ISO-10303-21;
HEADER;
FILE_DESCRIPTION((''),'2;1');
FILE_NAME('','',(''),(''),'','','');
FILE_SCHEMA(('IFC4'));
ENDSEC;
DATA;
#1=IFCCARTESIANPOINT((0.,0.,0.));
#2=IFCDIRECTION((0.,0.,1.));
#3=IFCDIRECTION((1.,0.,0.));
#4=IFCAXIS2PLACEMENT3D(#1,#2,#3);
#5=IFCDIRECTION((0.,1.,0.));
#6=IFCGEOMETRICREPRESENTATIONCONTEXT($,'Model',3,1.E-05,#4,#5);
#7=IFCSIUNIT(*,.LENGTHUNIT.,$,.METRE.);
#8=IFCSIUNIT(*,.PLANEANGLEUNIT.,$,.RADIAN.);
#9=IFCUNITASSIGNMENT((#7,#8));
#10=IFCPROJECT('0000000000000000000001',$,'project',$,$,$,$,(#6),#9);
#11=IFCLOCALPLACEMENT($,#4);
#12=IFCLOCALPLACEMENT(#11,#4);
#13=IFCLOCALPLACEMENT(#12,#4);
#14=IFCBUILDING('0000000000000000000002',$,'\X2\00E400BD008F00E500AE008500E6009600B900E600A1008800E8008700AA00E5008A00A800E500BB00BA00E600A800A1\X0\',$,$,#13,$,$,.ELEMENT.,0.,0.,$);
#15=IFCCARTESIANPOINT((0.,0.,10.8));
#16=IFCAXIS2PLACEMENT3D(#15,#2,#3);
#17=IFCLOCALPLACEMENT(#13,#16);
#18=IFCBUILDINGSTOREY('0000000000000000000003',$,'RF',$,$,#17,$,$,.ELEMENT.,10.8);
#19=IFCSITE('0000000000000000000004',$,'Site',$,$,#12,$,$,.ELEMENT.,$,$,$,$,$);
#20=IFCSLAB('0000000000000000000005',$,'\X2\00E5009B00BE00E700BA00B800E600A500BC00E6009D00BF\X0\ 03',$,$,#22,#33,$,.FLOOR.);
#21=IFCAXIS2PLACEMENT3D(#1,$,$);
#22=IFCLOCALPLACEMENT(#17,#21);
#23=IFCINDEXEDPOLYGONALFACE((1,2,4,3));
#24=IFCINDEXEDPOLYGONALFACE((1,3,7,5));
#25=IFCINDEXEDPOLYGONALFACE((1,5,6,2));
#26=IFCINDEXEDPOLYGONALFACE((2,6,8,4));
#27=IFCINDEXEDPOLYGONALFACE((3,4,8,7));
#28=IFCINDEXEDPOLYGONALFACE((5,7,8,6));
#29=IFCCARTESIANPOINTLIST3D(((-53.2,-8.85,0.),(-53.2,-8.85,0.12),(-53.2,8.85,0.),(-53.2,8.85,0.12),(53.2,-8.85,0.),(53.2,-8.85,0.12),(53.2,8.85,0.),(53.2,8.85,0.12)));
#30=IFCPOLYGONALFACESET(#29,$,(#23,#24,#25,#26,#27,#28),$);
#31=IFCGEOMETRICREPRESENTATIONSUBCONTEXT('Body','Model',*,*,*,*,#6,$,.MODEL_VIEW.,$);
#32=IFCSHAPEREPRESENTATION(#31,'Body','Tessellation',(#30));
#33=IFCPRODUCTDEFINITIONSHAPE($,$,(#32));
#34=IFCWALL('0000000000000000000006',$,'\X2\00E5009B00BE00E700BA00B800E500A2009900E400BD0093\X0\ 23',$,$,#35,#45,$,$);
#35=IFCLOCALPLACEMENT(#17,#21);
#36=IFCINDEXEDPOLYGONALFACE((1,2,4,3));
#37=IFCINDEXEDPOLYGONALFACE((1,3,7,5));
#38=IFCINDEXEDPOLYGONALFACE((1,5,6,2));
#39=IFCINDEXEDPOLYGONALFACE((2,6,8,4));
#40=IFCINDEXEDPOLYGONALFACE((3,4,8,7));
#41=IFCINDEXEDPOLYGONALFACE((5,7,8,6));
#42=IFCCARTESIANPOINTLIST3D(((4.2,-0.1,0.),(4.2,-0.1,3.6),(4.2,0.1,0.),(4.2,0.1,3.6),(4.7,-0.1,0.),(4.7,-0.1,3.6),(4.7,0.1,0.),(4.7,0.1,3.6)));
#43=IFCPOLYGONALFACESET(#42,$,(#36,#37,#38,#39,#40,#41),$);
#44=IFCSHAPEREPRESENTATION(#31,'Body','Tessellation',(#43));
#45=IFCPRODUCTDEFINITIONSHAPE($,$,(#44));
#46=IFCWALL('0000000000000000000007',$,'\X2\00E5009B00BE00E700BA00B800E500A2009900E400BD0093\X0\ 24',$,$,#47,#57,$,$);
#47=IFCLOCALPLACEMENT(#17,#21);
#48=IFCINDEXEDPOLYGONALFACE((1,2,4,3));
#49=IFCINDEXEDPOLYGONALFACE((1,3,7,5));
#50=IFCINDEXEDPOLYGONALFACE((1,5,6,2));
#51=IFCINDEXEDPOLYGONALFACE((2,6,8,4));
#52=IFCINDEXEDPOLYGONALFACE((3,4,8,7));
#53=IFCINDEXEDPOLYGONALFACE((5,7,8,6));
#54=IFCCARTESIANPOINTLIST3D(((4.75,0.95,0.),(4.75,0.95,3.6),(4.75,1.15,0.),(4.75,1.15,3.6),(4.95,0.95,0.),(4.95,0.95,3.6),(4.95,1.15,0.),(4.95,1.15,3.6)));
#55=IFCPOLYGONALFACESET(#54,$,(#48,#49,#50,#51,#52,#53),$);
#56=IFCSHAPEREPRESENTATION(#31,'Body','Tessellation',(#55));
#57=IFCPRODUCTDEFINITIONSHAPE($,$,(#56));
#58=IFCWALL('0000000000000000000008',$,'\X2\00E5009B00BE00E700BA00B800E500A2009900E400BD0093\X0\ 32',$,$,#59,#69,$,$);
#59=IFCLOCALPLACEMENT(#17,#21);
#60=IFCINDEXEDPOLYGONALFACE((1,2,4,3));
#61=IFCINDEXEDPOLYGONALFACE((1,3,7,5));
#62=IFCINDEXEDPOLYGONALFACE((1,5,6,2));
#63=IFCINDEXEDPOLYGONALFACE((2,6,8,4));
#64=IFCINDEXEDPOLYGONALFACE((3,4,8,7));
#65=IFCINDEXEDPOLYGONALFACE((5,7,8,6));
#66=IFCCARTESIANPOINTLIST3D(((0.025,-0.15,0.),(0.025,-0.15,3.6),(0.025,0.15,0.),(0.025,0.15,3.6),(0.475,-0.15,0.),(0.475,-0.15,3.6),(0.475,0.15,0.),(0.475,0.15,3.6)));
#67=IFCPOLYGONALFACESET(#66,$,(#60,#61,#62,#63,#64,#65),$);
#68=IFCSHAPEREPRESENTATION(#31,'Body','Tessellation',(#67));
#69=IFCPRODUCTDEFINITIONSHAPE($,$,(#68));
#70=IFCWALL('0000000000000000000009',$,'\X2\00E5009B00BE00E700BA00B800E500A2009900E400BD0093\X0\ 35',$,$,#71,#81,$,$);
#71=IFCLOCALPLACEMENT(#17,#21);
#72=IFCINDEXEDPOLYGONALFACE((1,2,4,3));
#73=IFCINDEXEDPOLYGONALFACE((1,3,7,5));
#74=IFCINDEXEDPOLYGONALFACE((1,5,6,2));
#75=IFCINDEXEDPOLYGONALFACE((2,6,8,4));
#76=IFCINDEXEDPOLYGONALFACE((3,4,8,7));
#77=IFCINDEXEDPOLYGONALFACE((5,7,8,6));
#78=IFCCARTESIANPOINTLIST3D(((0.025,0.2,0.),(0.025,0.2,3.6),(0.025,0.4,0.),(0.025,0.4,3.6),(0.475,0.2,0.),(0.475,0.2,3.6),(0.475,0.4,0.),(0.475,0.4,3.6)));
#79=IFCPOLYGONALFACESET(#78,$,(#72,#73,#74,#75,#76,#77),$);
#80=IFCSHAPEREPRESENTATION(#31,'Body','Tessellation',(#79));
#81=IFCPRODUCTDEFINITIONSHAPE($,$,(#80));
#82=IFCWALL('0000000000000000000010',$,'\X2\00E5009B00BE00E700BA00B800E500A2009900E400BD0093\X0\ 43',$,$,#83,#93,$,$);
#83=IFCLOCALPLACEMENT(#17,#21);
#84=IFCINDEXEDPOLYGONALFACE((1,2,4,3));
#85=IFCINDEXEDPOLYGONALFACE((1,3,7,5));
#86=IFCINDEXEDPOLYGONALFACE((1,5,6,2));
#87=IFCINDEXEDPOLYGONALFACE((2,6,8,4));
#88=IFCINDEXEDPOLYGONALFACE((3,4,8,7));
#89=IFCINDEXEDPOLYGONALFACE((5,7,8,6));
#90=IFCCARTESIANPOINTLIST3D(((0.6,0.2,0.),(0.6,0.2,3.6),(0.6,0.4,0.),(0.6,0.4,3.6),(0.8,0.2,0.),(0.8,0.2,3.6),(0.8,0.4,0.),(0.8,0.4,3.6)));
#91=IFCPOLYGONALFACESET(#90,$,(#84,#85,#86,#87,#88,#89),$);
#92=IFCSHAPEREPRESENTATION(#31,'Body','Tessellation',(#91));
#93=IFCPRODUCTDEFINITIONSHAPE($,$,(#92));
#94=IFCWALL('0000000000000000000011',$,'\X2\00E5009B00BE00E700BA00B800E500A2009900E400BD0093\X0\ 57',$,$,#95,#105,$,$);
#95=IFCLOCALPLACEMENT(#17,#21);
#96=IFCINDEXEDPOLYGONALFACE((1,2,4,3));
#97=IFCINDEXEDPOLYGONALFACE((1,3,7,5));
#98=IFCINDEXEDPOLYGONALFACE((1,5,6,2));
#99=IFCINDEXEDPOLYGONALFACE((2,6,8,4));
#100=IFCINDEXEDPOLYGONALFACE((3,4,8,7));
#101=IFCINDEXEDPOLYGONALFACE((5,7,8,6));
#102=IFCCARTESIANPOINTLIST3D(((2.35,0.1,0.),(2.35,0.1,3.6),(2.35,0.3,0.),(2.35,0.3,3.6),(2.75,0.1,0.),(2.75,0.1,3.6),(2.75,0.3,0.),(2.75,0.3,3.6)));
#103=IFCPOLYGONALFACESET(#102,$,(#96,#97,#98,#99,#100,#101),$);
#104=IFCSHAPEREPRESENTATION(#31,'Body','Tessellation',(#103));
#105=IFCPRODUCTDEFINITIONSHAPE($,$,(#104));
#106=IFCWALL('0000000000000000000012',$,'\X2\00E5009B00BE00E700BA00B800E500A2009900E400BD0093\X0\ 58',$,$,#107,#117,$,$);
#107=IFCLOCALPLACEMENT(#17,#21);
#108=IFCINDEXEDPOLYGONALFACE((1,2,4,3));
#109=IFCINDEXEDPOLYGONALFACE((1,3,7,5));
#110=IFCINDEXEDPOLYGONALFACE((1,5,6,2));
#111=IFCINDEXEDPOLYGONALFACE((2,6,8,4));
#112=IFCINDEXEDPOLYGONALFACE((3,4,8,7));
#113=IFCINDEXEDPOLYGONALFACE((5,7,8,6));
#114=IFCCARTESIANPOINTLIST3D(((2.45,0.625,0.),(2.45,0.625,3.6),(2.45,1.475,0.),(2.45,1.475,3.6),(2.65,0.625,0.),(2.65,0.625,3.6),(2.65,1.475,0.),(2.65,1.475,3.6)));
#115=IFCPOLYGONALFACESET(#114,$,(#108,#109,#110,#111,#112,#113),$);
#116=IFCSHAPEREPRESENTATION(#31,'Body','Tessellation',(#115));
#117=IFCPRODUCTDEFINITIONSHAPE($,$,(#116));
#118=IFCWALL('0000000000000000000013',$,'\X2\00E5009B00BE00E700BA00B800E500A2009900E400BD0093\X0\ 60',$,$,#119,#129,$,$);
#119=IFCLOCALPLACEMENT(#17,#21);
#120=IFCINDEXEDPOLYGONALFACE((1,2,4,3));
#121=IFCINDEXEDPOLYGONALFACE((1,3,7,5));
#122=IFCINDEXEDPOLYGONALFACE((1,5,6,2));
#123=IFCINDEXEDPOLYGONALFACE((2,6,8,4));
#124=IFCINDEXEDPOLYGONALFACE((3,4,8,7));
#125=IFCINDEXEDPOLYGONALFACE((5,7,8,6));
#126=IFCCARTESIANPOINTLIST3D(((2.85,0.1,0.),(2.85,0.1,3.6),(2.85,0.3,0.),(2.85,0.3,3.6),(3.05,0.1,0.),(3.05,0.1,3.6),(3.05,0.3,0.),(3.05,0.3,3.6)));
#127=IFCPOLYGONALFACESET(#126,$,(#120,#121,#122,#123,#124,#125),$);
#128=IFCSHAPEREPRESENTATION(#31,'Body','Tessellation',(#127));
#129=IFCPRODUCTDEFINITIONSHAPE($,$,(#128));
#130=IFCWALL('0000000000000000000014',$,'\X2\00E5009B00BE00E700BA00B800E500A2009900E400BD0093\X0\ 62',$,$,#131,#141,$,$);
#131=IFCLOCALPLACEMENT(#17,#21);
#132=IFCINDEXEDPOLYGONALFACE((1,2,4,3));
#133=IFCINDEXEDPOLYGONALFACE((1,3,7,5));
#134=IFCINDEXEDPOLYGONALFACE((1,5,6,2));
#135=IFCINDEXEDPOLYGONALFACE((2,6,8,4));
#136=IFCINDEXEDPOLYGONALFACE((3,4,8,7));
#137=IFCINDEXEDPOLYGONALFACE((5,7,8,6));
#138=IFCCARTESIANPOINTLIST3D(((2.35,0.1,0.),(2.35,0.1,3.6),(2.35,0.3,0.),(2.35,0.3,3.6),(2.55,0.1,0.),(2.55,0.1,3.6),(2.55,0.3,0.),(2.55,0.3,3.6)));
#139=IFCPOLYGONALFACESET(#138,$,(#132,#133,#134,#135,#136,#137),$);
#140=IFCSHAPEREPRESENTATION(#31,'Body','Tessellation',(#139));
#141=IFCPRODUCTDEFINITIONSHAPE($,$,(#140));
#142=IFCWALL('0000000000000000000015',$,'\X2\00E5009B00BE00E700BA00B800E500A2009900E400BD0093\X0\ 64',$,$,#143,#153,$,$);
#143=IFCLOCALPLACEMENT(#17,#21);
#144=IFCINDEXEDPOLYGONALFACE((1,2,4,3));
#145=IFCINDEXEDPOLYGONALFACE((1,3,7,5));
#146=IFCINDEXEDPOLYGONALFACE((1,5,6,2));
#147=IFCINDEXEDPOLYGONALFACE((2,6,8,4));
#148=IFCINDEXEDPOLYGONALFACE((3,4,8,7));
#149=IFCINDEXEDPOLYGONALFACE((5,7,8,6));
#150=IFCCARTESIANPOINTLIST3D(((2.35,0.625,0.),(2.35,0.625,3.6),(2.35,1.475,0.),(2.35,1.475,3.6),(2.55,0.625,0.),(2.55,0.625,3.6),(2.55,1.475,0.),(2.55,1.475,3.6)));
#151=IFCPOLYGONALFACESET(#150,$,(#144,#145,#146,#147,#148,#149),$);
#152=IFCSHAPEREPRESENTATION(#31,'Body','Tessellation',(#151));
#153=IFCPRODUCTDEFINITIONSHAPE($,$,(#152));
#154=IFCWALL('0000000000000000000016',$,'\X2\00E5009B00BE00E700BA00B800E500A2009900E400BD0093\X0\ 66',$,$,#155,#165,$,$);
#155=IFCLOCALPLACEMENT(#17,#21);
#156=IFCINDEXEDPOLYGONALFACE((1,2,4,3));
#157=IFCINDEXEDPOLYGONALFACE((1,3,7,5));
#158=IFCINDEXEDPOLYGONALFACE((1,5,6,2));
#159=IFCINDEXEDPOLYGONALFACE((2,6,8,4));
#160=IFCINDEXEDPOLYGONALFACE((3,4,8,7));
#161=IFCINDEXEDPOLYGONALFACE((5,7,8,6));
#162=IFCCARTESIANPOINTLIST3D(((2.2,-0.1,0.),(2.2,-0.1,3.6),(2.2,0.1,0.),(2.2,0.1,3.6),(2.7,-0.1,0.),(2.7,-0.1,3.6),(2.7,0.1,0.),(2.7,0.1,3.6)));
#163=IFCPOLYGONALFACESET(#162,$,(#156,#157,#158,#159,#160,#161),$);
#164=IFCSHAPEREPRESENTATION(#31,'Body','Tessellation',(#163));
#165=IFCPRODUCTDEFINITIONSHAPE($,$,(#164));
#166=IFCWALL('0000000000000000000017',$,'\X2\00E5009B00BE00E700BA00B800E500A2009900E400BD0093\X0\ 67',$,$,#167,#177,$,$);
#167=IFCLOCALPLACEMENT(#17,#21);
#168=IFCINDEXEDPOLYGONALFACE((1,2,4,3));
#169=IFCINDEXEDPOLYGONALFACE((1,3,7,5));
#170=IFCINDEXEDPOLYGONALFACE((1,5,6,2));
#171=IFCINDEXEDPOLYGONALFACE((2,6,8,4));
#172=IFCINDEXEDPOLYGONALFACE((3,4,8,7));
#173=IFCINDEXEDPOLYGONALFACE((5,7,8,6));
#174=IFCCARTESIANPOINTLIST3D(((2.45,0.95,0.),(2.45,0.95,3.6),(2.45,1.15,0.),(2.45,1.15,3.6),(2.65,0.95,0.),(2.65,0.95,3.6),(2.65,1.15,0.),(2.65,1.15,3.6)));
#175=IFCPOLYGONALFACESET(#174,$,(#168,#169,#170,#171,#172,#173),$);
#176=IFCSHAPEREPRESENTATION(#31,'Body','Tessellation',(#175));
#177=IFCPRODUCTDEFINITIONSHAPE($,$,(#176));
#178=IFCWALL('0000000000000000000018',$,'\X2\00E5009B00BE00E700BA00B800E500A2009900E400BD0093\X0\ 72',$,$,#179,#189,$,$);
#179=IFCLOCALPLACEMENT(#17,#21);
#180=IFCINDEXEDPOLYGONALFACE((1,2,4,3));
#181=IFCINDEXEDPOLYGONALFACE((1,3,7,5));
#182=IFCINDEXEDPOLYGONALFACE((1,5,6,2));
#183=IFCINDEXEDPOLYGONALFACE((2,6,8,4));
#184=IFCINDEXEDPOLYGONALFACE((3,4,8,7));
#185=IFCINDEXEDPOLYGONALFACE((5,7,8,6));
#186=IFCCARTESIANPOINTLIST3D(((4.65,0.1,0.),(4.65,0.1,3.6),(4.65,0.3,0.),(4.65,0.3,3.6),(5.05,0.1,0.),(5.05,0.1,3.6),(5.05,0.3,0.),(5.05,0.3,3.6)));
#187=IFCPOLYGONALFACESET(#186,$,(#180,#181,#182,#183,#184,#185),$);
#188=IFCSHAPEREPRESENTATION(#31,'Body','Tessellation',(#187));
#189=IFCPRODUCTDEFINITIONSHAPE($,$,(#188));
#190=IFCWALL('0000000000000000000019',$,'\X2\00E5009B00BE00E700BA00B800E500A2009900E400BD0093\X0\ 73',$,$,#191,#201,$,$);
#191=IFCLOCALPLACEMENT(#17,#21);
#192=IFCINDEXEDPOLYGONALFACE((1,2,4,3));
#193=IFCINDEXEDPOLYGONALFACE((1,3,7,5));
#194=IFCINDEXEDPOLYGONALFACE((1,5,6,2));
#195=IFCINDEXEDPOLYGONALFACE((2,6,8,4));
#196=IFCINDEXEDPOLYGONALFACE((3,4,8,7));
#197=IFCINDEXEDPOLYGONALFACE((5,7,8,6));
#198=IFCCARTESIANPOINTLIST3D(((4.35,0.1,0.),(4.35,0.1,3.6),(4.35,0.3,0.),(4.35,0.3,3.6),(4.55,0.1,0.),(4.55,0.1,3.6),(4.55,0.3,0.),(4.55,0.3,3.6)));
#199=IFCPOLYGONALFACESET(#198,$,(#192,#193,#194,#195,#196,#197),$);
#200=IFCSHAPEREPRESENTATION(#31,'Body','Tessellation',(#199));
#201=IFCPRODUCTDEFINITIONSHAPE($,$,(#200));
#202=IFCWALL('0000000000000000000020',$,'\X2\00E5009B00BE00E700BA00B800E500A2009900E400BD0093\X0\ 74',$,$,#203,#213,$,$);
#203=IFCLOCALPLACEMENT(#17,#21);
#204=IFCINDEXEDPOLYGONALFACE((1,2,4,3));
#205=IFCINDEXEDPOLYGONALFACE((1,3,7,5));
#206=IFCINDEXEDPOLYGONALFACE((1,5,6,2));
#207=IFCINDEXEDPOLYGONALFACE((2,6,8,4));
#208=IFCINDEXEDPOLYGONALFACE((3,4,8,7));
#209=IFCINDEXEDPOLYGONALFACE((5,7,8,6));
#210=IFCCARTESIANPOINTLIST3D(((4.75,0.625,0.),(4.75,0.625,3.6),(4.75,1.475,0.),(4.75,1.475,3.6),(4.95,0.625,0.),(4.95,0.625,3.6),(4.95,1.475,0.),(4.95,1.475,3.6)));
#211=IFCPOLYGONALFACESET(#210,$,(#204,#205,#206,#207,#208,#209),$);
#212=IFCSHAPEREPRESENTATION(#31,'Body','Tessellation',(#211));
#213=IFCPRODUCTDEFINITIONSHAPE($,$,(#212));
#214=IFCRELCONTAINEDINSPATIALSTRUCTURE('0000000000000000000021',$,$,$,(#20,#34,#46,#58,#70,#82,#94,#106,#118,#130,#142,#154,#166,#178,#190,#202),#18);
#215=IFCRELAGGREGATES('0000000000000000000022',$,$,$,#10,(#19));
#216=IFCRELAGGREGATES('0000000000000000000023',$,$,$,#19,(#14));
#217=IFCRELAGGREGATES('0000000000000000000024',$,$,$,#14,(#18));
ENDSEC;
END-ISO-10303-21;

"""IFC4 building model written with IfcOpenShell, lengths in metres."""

from ifc_helpers import new_model, si_unit, direction, frame, frame_2d, origin_with_axes, place, context, subcontext, project, spatial, rectangle, extrude, element, save


model = new_model("IFC4")

# Units and contexts
model_context = context("Model", 3, precision=1e-05, world=origin_with_axes(), true_north=direction((0.0, 1.0, 0.0)))
body_context = subcontext(model_context, "Body", "Model", "MODEL_VIEW")
ifc_project = project(units=[si_unit("LENGTHUNIT", "METRE"), si_unit("PLANEANGLEUNIT", "RADIAN")], contexts=[model_context])

# Site, building, storey
placement = place(None, origin_with_axes())
site_placement = place(placement, origin_with_axes())
site = spatial("IfcSite", under=ifc_project, at=site_placement, Name="Site", CompositionType="ELEMENT")
building_placement = place(site_placement, origin_with_axes())
building = spatial("IfcBuilding", under=site, at=building_placement, Name="ä½\u008få®\u0085æ\u0096¹æ¡\u0088è\u0087ªå\u008a¨å»ºæ¨¡", CompositionType="ELEMENT", ElevationOfRefHeight=0.0, ElevationOfTerrain=0.0)
storey_placement = place(building_placement, frame((0.0, 0.0, 10.8), z_axis=(0.0, 0.0, 1.0), x_axis=(1.0, 0.0, 0.0)))
storey = spatial("IfcBuildingStorey", under=building, at=storey_placement, Name="RF", CompositionType="ELEMENT", Elevation=10.8)

# Slab
slab_placement = place(storey_placement, origin_with_axes())
element("IfcSlab", 1, at=slab_placement, inside=storey, Name="å\u009b¾çº¸æ¥¼æ\u009d¿ 03", PredefinedType="FLOOR", context=body_context, shape_type="SweptSolid", body=[
    extrude(rectangle(XDim=106.4, YDim=17.7, at=frame_2d((0.0, 0.0), x_axis=(1.0, 0.0, 0.0))), frame((0.0, 0.0, 0.0), z_axis=(0.0, 0.0, 1.0)), (0.0, 0.0, 1.0), 0.12),
])

# Walls
wall_1_placement = place(storey_placement, frame((4.45, 0.0, 0.0), z_axis=(0.0, 0.0, 1.0), x_axis=(1.0, 0.0, 0.0)))
element("IfcWall", 2, at=wall_1_placement, inside=storey, Name="å\u009b¾çº¸å¢\u0099ä½\u0093 23", context=body_context, shape_type="SweptSolid", body=[
    extrude(rectangle(XDim=0.5, YDim=0.2, at=frame_2d((0.0, 0.0), x_axis=(1.0, 0.0, 0.0))), frame((0.0, 0.0, 0.0), z_axis=(0.0, 0.0, 1.0)), (0.0, 0.0, 1.0), 3.6),
])
wall_2_placement = place(storey_placement, frame((4.85, 1.05, 0.0), z_axis=(0.0, 0.0, 1.0), x_axis=(1.0, 0.0, 0.0)))
element("IfcWall", 3, at=wall_2_placement, inside=storey, Name="å\u009b¾çº¸å¢\u0099ä½\u0093 24", context=body_context, shape_type="SweptSolid", body=[
    extrude(rectangle(XDim=0.2, YDim=0.2, at=frame_2d((0.0, 0.0), x_axis=(1.0, 0.0, 0.0))), frame((0.0, 0.0, 0.0), z_axis=(0.0, 0.0, 1.0)), (0.0, 0.0, 1.0), 3.6),
])
wall_3_placement = place(storey_placement, frame((0.25, 0.0, 0.0), z_axis=(0.0, 0.0, 1.0), x_axis=(1.0, 0.0, 0.0)))
element("IfcWall", 4, at=wall_3_placement, inside=storey, Name="å\u009b¾çº¸å¢\u0099ä½\u0093 32", context=body_context, shape_type="SweptSolid", body=[
    extrude(rectangle(XDim=0.45, YDim=0.3, at=frame_2d((0.0, 0.0), x_axis=(1.0, 0.0, 0.0))), frame((0.0, 0.0, 0.0), z_axis=(0.0, 0.0, 1.0)), (0.0, 0.0, 1.0), 3.6),
])
wall_4_placement = place(storey_placement, frame((0.25, 0.3, 0.0), z_axis=(0.0, 0.0, 1.0), x_axis=(1.0, 0.0, 0.0)))
element("IfcWall", 5, at=wall_4_placement, inside=storey, Name="å\u009b¾çº¸å¢\u0099ä½\u0093 35", context=body_context, shape_type="SweptSolid", body=[
    extrude(rectangle(XDim=0.45, YDim=0.2, at=frame_2d((0.0, 0.0), x_axis=(1.0, 0.0, 0.0))), frame((0.0, 0.0, 0.0), z_axis=(0.0, 0.0, 1.0)), (0.0, 0.0, 1.0), 3.6),
])
wall_5_placement = place(storey_placement, frame((0.7, 0.3, 0.0), z_axis=(0.0, 0.0, 1.0), x_axis=(0.0, -1.0, 0.0)))
element("IfcWall", 6, at=wall_5_placement, inside=storey, Name="å\u009b¾çº¸å¢\u0099ä½\u0093 43", context=body_context, shape_type="SweptSolid", body=[
    extrude(rectangle(XDim=0.2, YDim=0.2, at=frame_2d((0.0, 0.0), x_axis=(1.0, 0.0, 0.0))), frame((0.0, 0.0, 0.0), z_axis=(0.0, 0.0, 1.0)), (0.0, 0.0, 1.0), 3.6),
])
wall_6_placement = place(storey_placement, frame((2.55, 0.2, 0.0), z_axis=(0.0, 0.0, 1.0), x_axis=(1.0, 0.0, 0.0)))
element("IfcWall", 7, at=wall_6_placement, inside=storey, Name="å\u009b¾çº¸å¢\u0099ä½\u0093 57", context=body_context, shape_type="SweptSolid", body=[
    extrude(rectangle(XDim=0.4, YDim=0.2, at=frame_2d((0.0, 0.0), x_axis=(1.0, 0.0, 0.0))), frame((0.0, 0.0, 0.0), z_axis=(0.0, 0.0, 1.0)), (0.0, 0.0, 1.0), 3.6),
])
wall_7_placement = place(storey_placement, frame((2.55, 1.05, 0.0), z_axis=(0.0, 0.0, 1.0), x_axis=(0.0, -1.0, 0.0)))
element("IfcWall", 8, at=wall_7_placement, inside=storey, Name="å\u009b¾çº¸å¢\u0099ä½\u0093 58", context=body_context, shape_type="SweptSolid", body=[
    extrude(rectangle(XDim=0.85, YDim=0.2, at=frame_2d((0.0, 0.0), x_axis=(1.0, 0.0, 0.0))), frame((0.0, 0.0, 0.0), z_axis=(0.0, 0.0, 1.0)), (0.0, 0.0, 1.0), 3.6),
])
for number, where, z_axis, x_axis, name in (
    (9, (2.95, 0.2, 0.0), (0.0, 0.0, 1.0), (0.0, -1.0, 0.0), "å\u009b¾çº¸å¢\u0099ä½\u0093 60"),
    (10, (2.45, 0.2, 0.0), (0.0, 0.0, 1.0), (0.0, -1.0, 0.0), "å\u009b¾çº¸å¢\u0099ä½\u0093 62"),
):
    element("IfcWall", number, at=place(storey_placement, frame(where, z_axis=z_axis, x_axis=x_axis)), inside=storey, Name=name, context=body_context, shape_type="SweptSolid", body=[
        extrude(rectangle(XDim=0.2, YDim=0.2, at=frame_2d((0.0, 0.0), x_axis=(1.0, 0.0, 0.0))), frame((0.0, 0.0, 0.0), z_axis=(0.0, 0.0, 1.0)), (0.0, 0.0, 1.0), 3.6),
    ])
wall_8_placement = place(storey_placement, frame((2.45, 1.05, 0.0), z_axis=(0.0, 0.0, 1.0), x_axis=(0.0, -1.0, 0.0)))
element("IfcWall", 11, at=wall_8_placement, inside=storey, Name="å\u009b¾çº¸å¢\u0099ä½\u0093 64", context=body_context, shape_type="SweptSolid", body=[
    extrude(rectangle(XDim=0.85, YDim=0.2, at=frame_2d((0.0, 0.0), x_axis=(1.0, 0.0, 0.0))), frame((0.0, 0.0, 0.0), z_axis=(0.0, 0.0, 1.0)), (0.0, 0.0, 1.0), 3.6),
])
wall_9_placement = place(storey_placement, frame((2.45, 0.0, 0.0), z_axis=(0.0, 0.0, 1.0), x_axis=(1.0, 0.0, 0.0)))
element("IfcWall", 12, at=wall_9_placement, inside=storey, Name="å\u009b¾çº¸å¢\u0099ä½\u0093 66", context=body_context, shape_type="SweptSolid", body=[
    extrude(rectangle(XDim=0.5, YDim=0.2, at=frame_2d((0.0, 0.0), x_axis=(1.0, 0.0, 0.0))), frame((0.0, 0.0, 0.0), z_axis=(0.0, 0.0, 1.0)), (0.0, 0.0, 1.0), 3.6),
])
wall_10_placement = place(storey_placement, frame((2.55, 1.05, 0.0), z_axis=(0.0, 0.0, 1.0), x_axis=(-1.0, 0.0, 0.0)))
element("IfcWall", 13, at=wall_10_placement, inside=storey, Name="å\u009b¾çº¸å¢\u0099ä½\u0093 67", context=body_context, shape_type="SweptSolid", body=[
    extrude(rectangle(XDim=0.2, YDim=0.2, at=frame_2d((0.0, 0.0), x_axis=(1.0, 0.0, 0.0))), frame((0.0, 0.0, 0.0), z_axis=(0.0, 0.0, 1.0)), (0.0, 0.0, 1.0), 3.6),
])
wall_11_placement = place(storey_placement, frame((4.85, 0.2, 0.0), z_axis=(0.0, 0.0, 1.0), x_axis=(-1.0, 0.0, 0.0)))
element("IfcWall", 14, at=wall_11_placement, inside=storey, Name="å\u009b¾çº¸å¢\u0099ä½\u0093 72", context=body_context, shape_type="SweptSolid", body=[
    extrude(rectangle(XDim=0.4, YDim=0.2, at=frame_2d((0.0, 0.0), x_axis=(1.0, 0.0, 0.0))), frame((0.0, 0.0, 0.0), z_axis=(0.0, 0.0, 1.0)), (0.0, 0.0, 1.0), 3.6),
])
wall_12_placement = place(storey_placement, frame((4.45, 0.2, 0.0), z_axis=(0.0, 0.0, 1.0), x_axis=(0.0, -1.0, 0.0)))
element("IfcWall", 15, at=wall_12_placement, inside=storey, Name="å\u009b¾çº¸å¢\u0099ä½\u0093 73", context=body_context, shape_type="SweptSolid", body=[
    extrude(rectangle(XDim=0.2, YDim=0.2, at=frame_2d((0.0, 0.0), x_axis=(1.0, 0.0, 0.0))), frame((0.0, 0.0, 0.0), z_axis=(0.0, 0.0, 1.0)), (0.0, 0.0, 1.0), 3.6),
])
wall_13_placement = place(storey_placement, frame((4.85, 1.05, 0.0), z_axis=(0.0, 0.0, 1.0), x_axis=(0.0, -1.0, 0.0)))
element("IfcWall", 16, at=wall_13_placement, inside=storey, Name="å\u009b¾çº¸å¢\u0099ä½\u0093 74", context=body_context, shape_type="SweptSolid", body=[
    extrude(rectangle(XDim=0.85, YDim=0.2, at=frame_2d((0.0, 0.0), x_axis=(1.0, 0.0, 0.0))), frame((0.0, 0.0, 0.0), z_axis=(0.0, 0.0, 1.0)), (0.0, 0.0, 1.0), 3.6),
])

save(model, "model.ifc")
